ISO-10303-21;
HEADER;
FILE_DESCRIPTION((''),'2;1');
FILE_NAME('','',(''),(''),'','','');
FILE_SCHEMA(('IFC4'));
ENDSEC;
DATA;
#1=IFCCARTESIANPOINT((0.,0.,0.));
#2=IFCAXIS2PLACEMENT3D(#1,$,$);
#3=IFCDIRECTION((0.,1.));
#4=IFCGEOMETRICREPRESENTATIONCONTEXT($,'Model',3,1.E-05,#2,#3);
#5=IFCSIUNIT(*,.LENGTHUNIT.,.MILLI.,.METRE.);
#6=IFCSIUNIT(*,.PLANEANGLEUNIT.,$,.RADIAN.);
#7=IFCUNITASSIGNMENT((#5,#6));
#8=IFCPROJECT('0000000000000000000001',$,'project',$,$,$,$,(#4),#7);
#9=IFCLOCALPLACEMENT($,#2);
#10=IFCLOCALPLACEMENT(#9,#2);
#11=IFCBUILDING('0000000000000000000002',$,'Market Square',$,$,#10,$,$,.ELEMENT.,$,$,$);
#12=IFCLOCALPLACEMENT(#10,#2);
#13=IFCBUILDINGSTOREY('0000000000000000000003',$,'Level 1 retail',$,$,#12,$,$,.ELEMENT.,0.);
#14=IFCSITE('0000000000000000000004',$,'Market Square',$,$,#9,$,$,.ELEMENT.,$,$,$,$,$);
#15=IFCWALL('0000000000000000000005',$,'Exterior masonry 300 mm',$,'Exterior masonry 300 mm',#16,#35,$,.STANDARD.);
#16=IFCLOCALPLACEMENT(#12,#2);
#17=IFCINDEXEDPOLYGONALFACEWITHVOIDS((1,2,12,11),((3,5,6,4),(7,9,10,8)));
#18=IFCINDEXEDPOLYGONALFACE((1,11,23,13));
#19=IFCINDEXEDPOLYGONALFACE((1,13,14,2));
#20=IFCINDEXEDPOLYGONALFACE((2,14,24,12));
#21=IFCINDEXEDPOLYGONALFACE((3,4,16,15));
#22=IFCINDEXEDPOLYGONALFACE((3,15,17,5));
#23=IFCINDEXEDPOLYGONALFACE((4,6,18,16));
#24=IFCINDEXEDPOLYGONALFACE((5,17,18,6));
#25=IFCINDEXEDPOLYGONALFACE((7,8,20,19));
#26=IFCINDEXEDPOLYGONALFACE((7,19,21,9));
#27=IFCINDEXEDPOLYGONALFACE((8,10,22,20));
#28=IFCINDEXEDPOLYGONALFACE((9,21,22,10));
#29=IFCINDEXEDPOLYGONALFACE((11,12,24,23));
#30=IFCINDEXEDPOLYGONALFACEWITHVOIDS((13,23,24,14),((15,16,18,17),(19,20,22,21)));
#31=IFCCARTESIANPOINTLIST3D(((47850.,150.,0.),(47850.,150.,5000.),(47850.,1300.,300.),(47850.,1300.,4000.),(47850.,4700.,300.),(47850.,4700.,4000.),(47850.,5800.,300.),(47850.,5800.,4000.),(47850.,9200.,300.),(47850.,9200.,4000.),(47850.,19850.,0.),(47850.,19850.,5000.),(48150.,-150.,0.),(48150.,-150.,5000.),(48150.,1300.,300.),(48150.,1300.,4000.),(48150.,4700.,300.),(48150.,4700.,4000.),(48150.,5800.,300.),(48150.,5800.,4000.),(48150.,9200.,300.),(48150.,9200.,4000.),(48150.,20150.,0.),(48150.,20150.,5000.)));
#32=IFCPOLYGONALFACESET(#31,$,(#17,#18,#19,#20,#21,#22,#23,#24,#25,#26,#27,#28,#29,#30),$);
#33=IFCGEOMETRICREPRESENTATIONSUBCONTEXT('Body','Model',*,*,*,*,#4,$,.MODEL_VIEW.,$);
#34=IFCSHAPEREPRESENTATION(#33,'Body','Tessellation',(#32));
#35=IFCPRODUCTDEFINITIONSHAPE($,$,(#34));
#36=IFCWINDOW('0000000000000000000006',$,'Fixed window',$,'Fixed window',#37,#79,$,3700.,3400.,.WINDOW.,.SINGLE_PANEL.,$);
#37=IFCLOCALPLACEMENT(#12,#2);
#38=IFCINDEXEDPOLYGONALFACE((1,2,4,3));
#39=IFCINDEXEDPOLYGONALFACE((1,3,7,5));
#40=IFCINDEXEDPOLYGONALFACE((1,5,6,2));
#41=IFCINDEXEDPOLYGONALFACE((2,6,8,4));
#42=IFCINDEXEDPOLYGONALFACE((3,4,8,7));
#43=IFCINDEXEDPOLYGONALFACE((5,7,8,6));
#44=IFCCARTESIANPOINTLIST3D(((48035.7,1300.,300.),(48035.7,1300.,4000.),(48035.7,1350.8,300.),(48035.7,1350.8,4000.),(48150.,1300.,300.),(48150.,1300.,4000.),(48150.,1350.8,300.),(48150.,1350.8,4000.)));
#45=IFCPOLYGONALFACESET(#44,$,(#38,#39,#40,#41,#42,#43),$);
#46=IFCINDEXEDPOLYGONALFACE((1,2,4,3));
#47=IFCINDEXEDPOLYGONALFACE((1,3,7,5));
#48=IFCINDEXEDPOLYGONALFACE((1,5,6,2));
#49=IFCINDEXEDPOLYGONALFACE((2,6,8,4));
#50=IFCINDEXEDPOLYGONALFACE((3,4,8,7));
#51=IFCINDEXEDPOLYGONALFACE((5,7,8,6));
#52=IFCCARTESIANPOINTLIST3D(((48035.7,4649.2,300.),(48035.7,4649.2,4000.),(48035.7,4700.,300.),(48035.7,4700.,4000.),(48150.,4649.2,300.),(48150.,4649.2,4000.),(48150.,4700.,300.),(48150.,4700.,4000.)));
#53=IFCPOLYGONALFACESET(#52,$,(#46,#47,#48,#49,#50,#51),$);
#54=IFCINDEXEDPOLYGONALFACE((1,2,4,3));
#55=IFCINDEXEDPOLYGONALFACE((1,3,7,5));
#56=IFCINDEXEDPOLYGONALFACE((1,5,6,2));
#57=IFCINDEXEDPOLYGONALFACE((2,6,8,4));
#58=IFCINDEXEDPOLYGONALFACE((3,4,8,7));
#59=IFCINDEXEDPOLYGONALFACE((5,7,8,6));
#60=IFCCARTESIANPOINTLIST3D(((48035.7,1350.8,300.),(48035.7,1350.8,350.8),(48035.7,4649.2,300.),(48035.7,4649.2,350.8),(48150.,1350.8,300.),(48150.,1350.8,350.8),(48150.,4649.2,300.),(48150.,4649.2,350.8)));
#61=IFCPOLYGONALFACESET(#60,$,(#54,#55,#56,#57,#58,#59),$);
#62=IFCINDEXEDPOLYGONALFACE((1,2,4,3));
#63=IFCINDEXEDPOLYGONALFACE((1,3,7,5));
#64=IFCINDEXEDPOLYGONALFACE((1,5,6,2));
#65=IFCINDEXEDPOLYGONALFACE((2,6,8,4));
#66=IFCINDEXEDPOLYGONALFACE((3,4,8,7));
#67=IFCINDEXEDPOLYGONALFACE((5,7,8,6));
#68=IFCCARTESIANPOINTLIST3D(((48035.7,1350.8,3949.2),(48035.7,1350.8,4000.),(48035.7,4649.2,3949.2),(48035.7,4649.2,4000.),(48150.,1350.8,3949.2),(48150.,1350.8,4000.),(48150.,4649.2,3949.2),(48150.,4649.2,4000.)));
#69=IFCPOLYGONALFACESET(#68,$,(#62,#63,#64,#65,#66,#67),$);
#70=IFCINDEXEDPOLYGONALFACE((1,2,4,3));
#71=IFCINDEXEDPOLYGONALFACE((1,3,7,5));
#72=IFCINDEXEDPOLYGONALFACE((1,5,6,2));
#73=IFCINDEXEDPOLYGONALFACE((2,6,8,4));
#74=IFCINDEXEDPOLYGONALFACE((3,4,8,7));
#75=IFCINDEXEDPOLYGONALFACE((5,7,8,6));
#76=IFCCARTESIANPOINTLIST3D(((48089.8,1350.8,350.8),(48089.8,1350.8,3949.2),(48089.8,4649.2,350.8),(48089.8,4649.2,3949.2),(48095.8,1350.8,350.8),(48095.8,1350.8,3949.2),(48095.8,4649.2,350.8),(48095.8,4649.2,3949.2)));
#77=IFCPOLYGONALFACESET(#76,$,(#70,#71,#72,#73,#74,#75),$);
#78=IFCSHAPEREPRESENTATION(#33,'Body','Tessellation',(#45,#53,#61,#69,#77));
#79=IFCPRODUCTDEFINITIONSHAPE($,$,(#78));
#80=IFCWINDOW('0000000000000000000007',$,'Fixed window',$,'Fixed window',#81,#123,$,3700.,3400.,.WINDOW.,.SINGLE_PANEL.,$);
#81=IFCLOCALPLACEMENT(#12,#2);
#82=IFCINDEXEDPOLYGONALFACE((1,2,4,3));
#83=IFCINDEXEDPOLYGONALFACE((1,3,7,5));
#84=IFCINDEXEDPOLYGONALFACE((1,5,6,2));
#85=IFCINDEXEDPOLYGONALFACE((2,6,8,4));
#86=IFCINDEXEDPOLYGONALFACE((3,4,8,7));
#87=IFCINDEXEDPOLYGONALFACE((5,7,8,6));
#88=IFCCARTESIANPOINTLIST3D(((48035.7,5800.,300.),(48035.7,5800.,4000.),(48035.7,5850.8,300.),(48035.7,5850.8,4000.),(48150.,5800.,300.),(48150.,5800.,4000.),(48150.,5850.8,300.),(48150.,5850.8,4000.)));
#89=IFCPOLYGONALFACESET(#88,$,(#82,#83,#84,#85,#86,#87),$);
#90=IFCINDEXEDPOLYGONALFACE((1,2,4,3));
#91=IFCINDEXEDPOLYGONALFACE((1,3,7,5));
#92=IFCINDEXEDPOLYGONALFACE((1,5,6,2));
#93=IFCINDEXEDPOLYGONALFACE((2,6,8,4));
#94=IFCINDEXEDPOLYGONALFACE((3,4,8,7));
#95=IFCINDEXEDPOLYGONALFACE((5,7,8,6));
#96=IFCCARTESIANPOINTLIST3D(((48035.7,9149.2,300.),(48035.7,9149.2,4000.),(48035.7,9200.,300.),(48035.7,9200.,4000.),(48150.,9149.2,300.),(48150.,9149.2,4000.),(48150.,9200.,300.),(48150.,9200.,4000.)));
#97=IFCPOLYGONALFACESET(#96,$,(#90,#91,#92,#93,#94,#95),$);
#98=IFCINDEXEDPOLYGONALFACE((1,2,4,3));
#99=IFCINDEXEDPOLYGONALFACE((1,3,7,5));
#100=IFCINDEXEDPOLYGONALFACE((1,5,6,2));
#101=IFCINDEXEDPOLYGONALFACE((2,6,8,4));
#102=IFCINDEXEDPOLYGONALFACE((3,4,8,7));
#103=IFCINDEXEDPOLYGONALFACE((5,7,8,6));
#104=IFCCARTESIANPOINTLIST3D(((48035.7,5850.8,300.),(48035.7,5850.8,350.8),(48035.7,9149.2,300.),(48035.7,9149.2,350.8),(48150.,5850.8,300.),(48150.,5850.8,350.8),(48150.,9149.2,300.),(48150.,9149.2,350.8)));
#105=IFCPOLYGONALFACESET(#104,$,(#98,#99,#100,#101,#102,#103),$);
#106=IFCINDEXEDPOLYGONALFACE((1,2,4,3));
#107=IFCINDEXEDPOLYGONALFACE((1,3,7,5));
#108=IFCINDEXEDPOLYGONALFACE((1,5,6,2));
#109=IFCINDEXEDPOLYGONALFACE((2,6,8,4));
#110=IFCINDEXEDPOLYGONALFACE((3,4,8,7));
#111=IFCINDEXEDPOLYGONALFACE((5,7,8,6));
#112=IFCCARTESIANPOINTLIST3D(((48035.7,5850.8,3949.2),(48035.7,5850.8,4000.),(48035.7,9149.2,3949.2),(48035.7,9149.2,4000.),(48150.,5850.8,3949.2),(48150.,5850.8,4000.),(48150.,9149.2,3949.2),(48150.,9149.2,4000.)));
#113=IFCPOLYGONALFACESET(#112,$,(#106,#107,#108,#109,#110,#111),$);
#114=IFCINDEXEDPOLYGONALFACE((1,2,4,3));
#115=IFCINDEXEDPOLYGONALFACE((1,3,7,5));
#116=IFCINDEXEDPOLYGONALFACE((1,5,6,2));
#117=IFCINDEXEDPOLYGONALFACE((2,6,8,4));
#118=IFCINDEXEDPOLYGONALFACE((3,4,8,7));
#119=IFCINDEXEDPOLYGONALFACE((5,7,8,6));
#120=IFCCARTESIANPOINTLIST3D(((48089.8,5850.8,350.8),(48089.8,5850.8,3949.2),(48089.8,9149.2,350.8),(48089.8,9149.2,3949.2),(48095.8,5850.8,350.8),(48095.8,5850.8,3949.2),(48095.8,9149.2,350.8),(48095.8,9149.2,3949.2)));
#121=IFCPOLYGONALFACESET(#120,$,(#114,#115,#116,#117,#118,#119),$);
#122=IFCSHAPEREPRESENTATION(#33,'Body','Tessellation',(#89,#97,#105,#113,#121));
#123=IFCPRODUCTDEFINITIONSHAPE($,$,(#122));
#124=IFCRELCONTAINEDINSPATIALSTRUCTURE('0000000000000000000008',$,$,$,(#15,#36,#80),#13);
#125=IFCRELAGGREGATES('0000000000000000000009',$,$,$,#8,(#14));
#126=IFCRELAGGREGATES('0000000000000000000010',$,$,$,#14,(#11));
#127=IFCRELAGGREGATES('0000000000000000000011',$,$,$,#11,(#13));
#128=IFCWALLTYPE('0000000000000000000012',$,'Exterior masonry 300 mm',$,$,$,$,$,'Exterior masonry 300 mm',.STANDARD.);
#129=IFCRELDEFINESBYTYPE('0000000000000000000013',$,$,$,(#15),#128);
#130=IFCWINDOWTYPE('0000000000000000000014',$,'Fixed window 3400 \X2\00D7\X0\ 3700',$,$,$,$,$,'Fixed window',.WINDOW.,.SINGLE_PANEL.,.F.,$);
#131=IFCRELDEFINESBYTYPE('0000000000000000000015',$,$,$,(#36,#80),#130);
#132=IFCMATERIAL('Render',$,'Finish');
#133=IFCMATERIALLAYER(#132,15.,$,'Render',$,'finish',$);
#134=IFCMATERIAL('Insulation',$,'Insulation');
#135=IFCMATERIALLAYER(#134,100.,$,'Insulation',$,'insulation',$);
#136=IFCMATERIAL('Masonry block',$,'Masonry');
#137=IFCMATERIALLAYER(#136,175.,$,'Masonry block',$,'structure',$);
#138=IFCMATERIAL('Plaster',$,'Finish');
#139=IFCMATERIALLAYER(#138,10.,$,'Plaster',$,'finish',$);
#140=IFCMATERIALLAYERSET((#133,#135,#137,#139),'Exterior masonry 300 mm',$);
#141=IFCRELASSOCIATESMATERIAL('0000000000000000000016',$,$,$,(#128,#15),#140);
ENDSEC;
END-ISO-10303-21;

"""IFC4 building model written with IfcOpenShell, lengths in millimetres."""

from ifc_helpers import new_model, si_unit, direction, frame, origin, origin_with_axes, place, context, subcontext, project, spatial, polyline, outline, extrude, material, layer, layer_set, layer_usage, type_object, element, fill, save


model = new_model("IFC4")

# Units and contexts
model_context = context("Model", 3, precision=1e-05, world=origin(), true_north=direction((0.0, 1.0)))
body_context = subcontext(model_context, "Body", "Model", "MODEL_VIEW")
ifc_project = project(units=[si_unit("LENGTHUNIT", "METRE", prefix="MILLI"), si_unit("PLANEANGLEUNIT", "RADIAN")], contexts=[model_context])

# Site, building, storey
site_placement = place(None, origin())
site = spatial("IfcSite", under=ifc_project, at=site_placement, Name="Market Square", CompositionType="ELEMENT")
building_placement = place(site_placement, origin())
building = spatial("IfcBuilding", under=site, at=building_placement, Name="Market Square", CompositionType="ELEMENT")
storey_placement = place(building_placement, origin())
storey = spatial("IfcBuildingStorey", under=building, at=storey_placement, Name="Level 1 retail", CompositionType="ELEMENT", Elevation=0.0)

# Wall, openings, windows
ifc_material_1 = material(Name="Render", Category="Finish")
ifc_layer_1 = layer(ifc_material_1, 15.0, Name="Render", Category="finish")
ifc_material_2 = material(Name="Insulation", Category="Insulation")
ifc_layer_2 = layer(ifc_material_2, 100.0, Name="Insulation", Category="insulation")
ifc_material_3 = material(Name="Masonry block", Category="Masonry")
ifc_layer_3 = layer(ifc_material_3, 175.0, Name="Masonry block", Category="structure")
ifc_material_4 = material(Name="Plaster", Category="Finish")
ifc_layer_4 = layer(ifc_material_4, 10.0, Name="Plaster", Category="finish")
ifc_layer_set_1 = layer_set([ifc_layer_1, ifc_layer_2, ifc_layer_3, ifc_layer_4], Name="Exterior masonry 300 mm")
ifc_layer_usage_1 = layer_usage(ifc_layer_set_1, "AXIS2", "POSITIVE", -150.0)
wall_type_1 = type_object("IfcWallType", Name="Exterior masonry 300 mm", ElementType="Exterior masonry 300 mm", PredefinedType="STANDARD", material=ifc_layer_set_1)
wall_1_placement = place(storey_placement, frame((48000.0, 0.0, 0.0), z_axis=(0.0, 0.0, 1.0), x_axis=(0.0, 1.0, 0.0)))
wall_1 = element("IfcWall", 1, at=wall_1_placement, inside=storey, type_object=wall_type_1, material=ifc_layer_usage_1, Name="Exterior masonry 300 mm", ObjectType="Exterior masonry 300 mm", PredefinedType="STANDARD", context=body_context, shape_type="SweptSolid", body=[
    extrude(outline(polyline([(-150.0, -150.0), (20150.0, -150.0), (19850.0, 150.0), (150.0, 150.0), (-150.0, -150.0)])), origin(), (0.0, 0.0, 1.0), 5000.0),
])
opening_1_placement = place(wall_1_placement, frame((1300.0, 0.0, 300.0), z_axis=(0.0, 0.0, 1.0), x_axis=(1.0, 0.0, 0.0)))
opening_1 = element("IfcOpeningElement", 2, at=opening_1_placement, cuts=wall_1, PredefinedType="OPENING", context=body_context, shape_type="SweptSolid", body=[
    extrude(outline(polyline([(0.0, -160.0), (3400.0, -160.0), (3400.0, 160.0), (0.0, 160.0), (0.0, -160.0)])), origin(), (0.0, 0.0, 1.0), 3700.0),
])
opening_2_placement = place(wall_1_placement, frame((5800.0, 0.0, 300.0), z_axis=(0.0, 0.0, 1.0), x_axis=(1.0, 0.0, 0.0)))
opening_2 = element("IfcOpeningElement", 3, at=opening_2_placement, cuts=wall_1, PredefinedType="OPENING", context=body_context, shape_type="SweptSolid", body=[
    extrude(outline(polyline([(0.0, -160.0), (3400.0, -160.0), (3400.0, 160.0), (0.0, 160.0), (0.0, -160.0)])), origin(), (0.0, 0.0, 1.0), 3700.0),
])
window_type = type_object("IfcWindowType", Name="Fixed window 3400 × 3700", ElementType="Fixed window", ParameterTakesPrecedence=False, PartitioningType="SINGLE_PANEL", PredefinedType="WINDOW")
window_1_placement = place(opening_1_placement, origin_with_axes())
window_1 = element("IfcWindow", 4, at=window_1_placement, inside=storey, type_object=window_type, Name="Fixed window", ObjectType="Fixed window", OverallHeight=3700.0, OverallWidth=3400.0, PartitioningType="SINGLE_PANEL", PredefinedType="WINDOW", context=body_context, shape_type="SweptSolid", body=[
    extrude(outline(polyline([(0.0, -150.0), (50.8, -150.0), (50.8, -35.7), (0.0, -35.7), (0.0, -150.0)])), origin(), (0.0, 0.0, 1.0), 3700.0),
    extrude(outline(polyline([(3349.2, -150.0), (3400.0, -150.0), (3400.0, -35.7), (3349.2, -35.7), (3349.2, -150.0)])), origin(), (0.0, 0.0, 1.0), 3700.0),
    extrude(outline(polyline([(50.8, -150.0), (3349.2, -150.0), (3349.2, -35.7), (50.8, -35.7), (50.8, -150.0)])), origin(), (0.0, 0.0, 1.0), 50.8),
    extrude(outline(polyline([(50.8, -150.0), (3349.2, -150.0), (3349.2, -35.7), (50.8, -35.7), (50.8, -150.0)])), frame((0.0, 0.0, 3649.2)), (0.0, 0.0, 1.0), 50.8),
    extrude(outline(polyline([(50.8, -95.8), (3349.2, -95.8), (3349.2, -89.8), (50.8, -89.8), (50.8, -95.8)])), frame((0.0, 0.0, 50.8)), (0.0, 0.0, 1.0), 3598.4),
])
fill(opening_1, window_1)
window_2_placement = place(opening_2_placement, origin_with_axes())
window_2 = element("IfcWindow", 5, at=window_2_placement, inside=storey, type_object=window_type, Name="Fixed window", ObjectType="Fixed window", OverallHeight=3700.0, OverallWidth=3400.0, PartitioningType="SINGLE_PANEL", PredefinedType="WINDOW", context=body_context, shape_type="SweptSolid", body=[
    extrude(outline(polyline([(0.0, -150.0), (50.8, -150.0), (50.8, -35.7), (0.0, -35.7), (0.0, -150.0)])), origin(), (0.0, 0.0, 1.0), 3700.0),
    extrude(outline(polyline([(3349.2, -150.0), (3400.0, -150.0), (3400.0, -35.7), (3349.2, -35.7), (3349.2, -150.0)])), origin(), (0.0, 0.0, 1.0), 3700.0),
    extrude(outline(polyline([(50.8, -150.0), (3349.2, -150.0), (3349.2, -35.7), (50.8, -35.7), (50.8, -150.0)])), origin(), (0.0, 0.0, 1.0), 50.8),
    extrude(outline(polyline([(50.8, -150.0), (3349.2, -150.0), (3349.2, -35.7), (50.8, -35.7), (50.8, -150.0)])), frame((0.0, 0.0, 3649.2)), (0.0, 0.0, 1.0), 50.8),
    extrude(outline(polyline([(50.8, -95.8), (3349.2, -95.8), (3349.2, -89.8), (50.8, -89.8), (50.8, -95.8)])), frame((0.0, 0.0, 50.8)), (0.0, 0.0, 1.0), 3598.4),
])
fill(opening_2, window_2)

save(model, "model.ifc")
